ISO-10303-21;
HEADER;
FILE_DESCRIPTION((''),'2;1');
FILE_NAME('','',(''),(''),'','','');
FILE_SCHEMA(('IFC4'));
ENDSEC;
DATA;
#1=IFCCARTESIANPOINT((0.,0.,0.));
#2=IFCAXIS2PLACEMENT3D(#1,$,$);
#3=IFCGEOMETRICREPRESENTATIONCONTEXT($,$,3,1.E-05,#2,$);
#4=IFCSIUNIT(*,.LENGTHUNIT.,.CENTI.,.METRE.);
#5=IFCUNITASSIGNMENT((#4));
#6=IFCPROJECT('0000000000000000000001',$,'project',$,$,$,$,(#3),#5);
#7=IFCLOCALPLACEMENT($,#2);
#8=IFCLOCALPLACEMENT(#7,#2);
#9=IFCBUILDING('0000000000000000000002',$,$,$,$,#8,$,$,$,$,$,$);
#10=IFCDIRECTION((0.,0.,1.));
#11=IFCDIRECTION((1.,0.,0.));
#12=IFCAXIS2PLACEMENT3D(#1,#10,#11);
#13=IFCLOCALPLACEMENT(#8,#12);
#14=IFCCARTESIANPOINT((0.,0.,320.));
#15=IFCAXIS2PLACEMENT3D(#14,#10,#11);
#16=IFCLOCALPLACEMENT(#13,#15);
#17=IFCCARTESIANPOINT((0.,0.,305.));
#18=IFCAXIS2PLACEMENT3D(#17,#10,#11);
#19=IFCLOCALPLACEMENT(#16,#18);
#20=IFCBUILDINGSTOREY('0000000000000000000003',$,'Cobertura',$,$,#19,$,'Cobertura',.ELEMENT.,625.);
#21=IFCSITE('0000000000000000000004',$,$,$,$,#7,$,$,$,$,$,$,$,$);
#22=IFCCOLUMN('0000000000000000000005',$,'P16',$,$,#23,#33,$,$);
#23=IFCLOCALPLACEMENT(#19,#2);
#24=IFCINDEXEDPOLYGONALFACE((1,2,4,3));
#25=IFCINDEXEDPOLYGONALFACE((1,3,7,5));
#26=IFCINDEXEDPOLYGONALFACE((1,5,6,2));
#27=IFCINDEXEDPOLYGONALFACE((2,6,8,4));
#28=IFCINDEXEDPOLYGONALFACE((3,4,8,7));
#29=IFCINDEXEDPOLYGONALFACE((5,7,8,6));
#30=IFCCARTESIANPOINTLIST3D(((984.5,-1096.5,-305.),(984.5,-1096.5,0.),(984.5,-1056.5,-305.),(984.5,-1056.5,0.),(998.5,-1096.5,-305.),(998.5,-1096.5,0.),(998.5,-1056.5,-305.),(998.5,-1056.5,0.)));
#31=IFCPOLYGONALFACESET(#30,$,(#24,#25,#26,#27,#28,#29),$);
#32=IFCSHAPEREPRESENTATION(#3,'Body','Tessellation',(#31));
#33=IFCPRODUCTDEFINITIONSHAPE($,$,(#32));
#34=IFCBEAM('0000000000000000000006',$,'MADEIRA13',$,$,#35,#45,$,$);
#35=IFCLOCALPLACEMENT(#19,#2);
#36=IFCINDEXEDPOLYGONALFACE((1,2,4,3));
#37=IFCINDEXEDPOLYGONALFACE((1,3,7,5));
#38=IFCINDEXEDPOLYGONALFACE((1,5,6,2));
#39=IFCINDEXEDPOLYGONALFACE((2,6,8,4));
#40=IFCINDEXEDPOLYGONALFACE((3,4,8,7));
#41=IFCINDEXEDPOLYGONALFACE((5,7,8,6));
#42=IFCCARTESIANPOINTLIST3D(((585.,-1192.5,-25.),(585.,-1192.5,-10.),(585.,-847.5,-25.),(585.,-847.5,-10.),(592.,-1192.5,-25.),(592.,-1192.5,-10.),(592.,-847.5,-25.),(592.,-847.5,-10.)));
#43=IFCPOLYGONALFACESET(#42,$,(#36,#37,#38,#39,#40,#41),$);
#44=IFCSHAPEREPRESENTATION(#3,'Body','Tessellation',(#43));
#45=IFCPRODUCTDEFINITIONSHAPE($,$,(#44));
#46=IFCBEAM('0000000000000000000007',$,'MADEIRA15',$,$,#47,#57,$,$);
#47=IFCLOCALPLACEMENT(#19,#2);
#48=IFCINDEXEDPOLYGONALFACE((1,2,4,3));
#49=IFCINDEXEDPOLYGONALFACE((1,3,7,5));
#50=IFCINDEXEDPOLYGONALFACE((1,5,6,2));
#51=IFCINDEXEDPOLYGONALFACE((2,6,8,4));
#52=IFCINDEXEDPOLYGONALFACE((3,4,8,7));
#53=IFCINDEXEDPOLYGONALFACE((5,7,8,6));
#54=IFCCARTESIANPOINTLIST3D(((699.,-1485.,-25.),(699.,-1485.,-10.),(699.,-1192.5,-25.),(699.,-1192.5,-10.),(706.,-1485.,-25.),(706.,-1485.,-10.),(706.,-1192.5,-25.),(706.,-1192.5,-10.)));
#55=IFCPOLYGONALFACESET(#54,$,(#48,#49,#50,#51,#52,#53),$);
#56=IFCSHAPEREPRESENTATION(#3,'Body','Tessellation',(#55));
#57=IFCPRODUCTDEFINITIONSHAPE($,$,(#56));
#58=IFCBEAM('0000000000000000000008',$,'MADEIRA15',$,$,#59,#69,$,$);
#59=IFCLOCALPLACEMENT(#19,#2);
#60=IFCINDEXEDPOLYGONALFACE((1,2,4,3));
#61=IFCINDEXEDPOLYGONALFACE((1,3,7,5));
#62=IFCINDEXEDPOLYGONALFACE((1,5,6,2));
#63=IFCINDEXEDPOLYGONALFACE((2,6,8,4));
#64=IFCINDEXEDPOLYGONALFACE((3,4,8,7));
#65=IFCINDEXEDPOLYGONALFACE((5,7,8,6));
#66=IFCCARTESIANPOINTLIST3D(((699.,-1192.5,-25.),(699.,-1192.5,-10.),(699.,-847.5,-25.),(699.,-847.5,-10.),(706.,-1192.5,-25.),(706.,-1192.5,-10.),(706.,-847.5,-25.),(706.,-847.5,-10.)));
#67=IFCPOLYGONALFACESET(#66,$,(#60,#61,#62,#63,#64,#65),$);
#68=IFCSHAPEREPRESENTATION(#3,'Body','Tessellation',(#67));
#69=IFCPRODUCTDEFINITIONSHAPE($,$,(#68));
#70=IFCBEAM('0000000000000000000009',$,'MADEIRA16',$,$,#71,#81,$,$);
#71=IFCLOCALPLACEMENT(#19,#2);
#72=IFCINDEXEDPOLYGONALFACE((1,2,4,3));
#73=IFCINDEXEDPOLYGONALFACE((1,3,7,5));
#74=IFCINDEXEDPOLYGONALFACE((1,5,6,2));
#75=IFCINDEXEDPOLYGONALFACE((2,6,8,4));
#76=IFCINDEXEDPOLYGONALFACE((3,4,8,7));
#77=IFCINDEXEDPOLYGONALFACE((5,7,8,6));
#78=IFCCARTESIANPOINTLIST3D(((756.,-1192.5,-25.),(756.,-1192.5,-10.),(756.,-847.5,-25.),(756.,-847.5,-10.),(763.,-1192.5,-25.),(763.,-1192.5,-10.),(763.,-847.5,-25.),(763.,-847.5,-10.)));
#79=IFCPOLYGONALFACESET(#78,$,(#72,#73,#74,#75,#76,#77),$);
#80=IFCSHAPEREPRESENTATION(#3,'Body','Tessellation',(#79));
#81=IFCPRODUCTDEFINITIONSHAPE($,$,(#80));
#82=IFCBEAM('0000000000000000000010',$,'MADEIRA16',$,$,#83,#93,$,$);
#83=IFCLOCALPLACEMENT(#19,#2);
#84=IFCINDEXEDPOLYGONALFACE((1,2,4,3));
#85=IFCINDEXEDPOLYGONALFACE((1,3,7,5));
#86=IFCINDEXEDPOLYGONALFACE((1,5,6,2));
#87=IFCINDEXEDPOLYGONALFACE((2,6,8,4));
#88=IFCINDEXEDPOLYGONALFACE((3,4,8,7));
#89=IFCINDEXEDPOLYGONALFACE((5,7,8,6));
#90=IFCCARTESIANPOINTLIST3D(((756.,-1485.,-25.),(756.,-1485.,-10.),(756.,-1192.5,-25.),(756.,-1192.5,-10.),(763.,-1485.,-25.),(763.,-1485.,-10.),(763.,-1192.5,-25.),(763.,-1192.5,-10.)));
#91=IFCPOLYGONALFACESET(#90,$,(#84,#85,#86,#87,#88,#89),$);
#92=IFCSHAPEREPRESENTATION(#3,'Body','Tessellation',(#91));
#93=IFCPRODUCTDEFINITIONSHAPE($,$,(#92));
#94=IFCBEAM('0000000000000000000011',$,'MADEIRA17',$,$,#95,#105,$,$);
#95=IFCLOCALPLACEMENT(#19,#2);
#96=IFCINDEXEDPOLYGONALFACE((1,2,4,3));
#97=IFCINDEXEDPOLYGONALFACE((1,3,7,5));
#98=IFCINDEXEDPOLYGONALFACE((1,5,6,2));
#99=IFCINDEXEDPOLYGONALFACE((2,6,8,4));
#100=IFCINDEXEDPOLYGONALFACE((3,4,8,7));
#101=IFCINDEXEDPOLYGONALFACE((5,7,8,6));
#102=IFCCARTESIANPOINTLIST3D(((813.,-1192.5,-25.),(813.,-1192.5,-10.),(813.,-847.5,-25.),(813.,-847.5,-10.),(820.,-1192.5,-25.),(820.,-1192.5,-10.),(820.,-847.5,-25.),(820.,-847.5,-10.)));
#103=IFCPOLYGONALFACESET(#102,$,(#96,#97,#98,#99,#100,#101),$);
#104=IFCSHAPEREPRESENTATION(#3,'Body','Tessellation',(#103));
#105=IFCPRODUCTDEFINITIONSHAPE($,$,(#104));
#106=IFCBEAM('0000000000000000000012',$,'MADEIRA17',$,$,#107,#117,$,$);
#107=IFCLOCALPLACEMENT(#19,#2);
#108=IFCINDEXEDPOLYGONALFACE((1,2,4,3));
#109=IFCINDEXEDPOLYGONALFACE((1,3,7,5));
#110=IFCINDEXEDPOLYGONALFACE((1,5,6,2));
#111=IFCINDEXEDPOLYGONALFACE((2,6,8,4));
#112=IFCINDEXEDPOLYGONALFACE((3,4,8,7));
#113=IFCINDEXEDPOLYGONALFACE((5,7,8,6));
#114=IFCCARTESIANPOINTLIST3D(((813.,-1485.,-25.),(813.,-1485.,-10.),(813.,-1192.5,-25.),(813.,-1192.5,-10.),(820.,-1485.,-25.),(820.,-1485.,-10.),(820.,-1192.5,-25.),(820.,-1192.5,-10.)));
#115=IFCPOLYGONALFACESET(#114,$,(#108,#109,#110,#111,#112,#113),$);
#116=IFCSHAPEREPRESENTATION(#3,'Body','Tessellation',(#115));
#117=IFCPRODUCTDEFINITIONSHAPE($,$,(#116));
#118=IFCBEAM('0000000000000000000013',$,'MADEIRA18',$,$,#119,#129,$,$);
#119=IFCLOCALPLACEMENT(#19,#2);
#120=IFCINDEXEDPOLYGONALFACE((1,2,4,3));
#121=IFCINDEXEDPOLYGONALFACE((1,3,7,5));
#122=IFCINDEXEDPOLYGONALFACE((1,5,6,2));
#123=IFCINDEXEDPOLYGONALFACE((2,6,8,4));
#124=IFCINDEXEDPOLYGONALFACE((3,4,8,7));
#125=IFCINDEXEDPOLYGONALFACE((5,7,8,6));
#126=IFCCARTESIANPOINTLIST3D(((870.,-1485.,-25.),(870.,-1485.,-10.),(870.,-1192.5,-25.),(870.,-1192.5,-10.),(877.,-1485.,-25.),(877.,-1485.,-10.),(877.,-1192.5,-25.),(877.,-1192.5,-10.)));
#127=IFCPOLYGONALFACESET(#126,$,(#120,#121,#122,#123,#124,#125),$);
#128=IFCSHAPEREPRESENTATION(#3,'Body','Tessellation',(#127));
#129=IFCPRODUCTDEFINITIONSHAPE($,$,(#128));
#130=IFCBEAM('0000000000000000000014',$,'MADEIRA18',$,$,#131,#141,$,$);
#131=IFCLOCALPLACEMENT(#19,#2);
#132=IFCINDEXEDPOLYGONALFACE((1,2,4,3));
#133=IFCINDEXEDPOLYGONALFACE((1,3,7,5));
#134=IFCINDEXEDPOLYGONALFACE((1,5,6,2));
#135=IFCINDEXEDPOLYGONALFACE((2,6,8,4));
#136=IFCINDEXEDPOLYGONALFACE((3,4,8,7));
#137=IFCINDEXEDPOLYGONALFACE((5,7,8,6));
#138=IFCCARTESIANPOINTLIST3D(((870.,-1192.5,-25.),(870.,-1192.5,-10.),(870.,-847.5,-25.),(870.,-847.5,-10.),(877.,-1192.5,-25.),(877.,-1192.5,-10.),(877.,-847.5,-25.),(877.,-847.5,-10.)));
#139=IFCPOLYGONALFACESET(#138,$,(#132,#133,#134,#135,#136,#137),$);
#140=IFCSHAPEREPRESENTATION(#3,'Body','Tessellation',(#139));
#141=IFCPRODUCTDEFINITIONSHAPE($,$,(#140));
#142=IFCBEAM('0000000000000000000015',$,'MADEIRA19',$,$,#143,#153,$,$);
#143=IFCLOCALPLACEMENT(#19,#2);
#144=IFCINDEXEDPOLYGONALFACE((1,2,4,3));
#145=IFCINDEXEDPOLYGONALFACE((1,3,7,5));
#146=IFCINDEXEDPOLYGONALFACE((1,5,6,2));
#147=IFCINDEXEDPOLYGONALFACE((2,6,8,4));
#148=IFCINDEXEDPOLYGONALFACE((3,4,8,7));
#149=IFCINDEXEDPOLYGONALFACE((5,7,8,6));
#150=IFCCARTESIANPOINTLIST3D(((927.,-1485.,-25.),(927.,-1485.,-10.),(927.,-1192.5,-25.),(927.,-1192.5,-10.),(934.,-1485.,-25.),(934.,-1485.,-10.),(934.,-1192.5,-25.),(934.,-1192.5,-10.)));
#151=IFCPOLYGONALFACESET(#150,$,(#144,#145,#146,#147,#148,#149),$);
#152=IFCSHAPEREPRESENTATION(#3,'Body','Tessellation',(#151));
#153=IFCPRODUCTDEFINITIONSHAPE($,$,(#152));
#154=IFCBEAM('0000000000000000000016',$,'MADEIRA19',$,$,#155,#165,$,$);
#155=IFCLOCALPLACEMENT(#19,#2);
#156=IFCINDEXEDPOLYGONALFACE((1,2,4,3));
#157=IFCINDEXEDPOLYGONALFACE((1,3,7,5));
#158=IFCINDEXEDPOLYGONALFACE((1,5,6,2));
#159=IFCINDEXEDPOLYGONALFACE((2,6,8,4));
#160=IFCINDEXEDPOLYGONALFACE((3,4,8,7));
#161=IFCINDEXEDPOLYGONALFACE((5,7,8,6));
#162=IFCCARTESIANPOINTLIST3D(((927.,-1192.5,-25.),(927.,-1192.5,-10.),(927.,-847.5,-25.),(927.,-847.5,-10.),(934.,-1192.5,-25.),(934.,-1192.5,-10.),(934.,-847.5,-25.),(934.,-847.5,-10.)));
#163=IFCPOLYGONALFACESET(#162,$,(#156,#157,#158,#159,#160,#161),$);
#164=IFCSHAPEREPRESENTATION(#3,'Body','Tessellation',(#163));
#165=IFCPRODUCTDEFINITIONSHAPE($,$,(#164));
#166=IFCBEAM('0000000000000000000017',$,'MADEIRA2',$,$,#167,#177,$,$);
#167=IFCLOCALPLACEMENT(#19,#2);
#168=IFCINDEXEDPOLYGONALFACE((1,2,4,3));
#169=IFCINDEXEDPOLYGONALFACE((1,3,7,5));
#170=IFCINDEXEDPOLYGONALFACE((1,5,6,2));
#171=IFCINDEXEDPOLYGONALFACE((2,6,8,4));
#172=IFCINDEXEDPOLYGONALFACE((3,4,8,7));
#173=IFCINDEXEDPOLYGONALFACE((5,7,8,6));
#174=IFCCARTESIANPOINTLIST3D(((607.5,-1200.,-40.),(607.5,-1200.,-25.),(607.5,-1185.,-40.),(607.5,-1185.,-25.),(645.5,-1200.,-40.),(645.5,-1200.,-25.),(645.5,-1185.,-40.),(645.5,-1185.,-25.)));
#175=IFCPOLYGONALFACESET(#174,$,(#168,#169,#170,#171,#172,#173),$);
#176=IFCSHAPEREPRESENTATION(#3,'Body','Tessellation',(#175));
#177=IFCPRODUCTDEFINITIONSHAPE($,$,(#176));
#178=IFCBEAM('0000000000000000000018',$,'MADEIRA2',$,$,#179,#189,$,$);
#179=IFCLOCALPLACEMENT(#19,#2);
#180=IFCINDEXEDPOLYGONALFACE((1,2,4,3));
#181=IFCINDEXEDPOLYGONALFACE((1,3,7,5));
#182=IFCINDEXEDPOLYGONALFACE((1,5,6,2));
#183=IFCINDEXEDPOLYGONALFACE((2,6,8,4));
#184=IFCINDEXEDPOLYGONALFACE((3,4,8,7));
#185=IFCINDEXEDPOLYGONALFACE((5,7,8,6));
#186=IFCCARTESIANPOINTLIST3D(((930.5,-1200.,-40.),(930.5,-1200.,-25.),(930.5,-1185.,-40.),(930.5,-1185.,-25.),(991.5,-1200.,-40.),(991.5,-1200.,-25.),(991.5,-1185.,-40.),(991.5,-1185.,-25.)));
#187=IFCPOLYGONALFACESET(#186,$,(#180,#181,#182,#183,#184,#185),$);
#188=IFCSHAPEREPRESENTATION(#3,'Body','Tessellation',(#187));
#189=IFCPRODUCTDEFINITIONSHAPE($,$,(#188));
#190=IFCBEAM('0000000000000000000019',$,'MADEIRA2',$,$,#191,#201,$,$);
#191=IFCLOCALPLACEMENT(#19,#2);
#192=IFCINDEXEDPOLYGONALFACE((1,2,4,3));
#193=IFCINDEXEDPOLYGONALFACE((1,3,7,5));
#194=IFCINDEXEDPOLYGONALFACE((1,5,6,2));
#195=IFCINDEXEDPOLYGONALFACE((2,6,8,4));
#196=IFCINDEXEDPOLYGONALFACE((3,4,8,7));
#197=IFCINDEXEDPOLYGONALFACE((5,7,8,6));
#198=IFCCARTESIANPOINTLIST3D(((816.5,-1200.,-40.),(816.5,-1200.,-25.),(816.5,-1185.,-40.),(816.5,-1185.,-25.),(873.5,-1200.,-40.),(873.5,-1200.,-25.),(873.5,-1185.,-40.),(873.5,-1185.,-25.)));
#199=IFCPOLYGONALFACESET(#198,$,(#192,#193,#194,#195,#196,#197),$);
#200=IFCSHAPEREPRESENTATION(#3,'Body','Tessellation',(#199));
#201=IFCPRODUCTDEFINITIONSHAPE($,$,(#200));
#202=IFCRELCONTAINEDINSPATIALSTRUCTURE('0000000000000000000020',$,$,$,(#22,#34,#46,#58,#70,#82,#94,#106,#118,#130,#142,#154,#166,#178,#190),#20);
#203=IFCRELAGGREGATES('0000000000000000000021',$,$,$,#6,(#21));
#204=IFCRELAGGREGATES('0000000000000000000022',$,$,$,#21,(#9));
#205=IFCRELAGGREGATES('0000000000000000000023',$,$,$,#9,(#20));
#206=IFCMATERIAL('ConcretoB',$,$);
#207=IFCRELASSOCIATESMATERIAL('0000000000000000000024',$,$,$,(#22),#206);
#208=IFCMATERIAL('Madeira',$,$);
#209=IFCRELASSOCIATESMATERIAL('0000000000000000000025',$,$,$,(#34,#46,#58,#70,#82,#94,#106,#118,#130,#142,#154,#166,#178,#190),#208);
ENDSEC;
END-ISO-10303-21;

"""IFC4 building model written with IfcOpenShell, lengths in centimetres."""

from ifc_helpers import new_model, si_unit, frame, origin, origin_with_axes, place, context, project, spatial, polyline, outline, extrude, material, element, save


model = new_model("IFC4")

# Units and contexts
context_of_model = context(None, 3, precision=1e-05, world=origin())
ifc_project = project(units=[si_unit("LENGTHUNIT", "METRE", prefix="CENTI")], contexts=[context_of_model])

# Site, building, storey
site_placement = place(None, origin())
site = spatial("IfcSite", under=ifc_project, at=site_placement)
building_placement = place(site_placement, origin())
building = spatial("IfcBuilding", under=site, at=building_placement)
placement_1 = place(building_placement, origin_with_axes())
placement_2 = place(placement_1, frame((0.0, 0.0, 320.0), z_axis=(0.0, 0.0, 1.0), x_axis=(1.0, 0.0, 0.0)))
storey_placement = place(placement_2, frame((0.0, 0.0, 305.0), z_axis=(0.0, 0.0, 1.0), x_axis=(1.0, 0.0, 0.0)))
storey = spatial("IfcBuildingStorey", under=building, at=storey_placement, Name="Cobertura", LongName="Cobertura", CompositionType="ELEMENT", Elevation=625.0)

# Column
ifc_material_1 = material(Name="ConcretoB")
column_placement = place(storey_placement, frame((991.5, -1076.5, 0.0), z_axis=(0.0, 0.0, 1.0), x_axis=(1.0, 0.0, 0.0)))
element("IfcColumn", 1, at=column_placement, inside=storey, material=ifc_material_1, Name="P16", context=context_of_model, shape_type="SolidModel", body=[
    extrude(outline(polyline([(-7.0, -20.0), (7.0, -20.0), (7.0, 20.0), (-7.0, 20.0), (-7.0, -20.0)])), origin_with_axes(), (0.0, 0.0, -1.0), 305.0),
])

# Beams
ifc_material_2 = material(Name="Madeira")
beam_1_placement = place(storey_placement, frame((588.5, -1020.0, -10.0), z_axis=(0.0, 0.0, 1.0), x_axis=(1.0, 0.0, 0.0)))
element("IfcBeam", 2, at=beam_1_placement, inside=storey, material=ifc_material_2, Name="MADEIRA13", context=context_of_model, shape_type="SolidModel", body=[
    extrude(outline(polyline([(-3.5, -7.5), (-3.5, 7.5), (3.5, 7.5), (3.5, -7.5), (-3.5, -7.5)])), frame((0.0, -172.5, -7.5), z_axis=(0.0, 1.0, 0.0), x_axis=(1.0, 0.0, 0.0)), (0.0, 0.0, 1.0), 345.0),
])
beam_2_placement = place(storey_placement, frame((702.5, -1338.75, -10.0), z_axis=(0.0, 0.0, 1.0), x_axis=(1.0, 0.0, 0.0)))
element("IfcBeam", 3, at=beam_2_placement, inside=storey, material=ifc_material_2, Name="MADEIRA15", context=context_of_model, shape_type="SolidModel", body=[
    extrude(outline(polyline([(-3.5, -7.5), (-3.5, 7.5), (3.5, 7.5), (3.5, -7.5), (-3.5, -7.5)])), frame((0.0, -146.25, -7.5), z_axis=(0.0, 1.0, 0.0), x_axis=(1.0, 0.0, 0.0)), (0.0, 0.0, 1.0), 292.5),
])
for number, where, z_axis, x_axis, name in (
    (4, (702.5, -1020.0, -10.0), (0.0, 0.0, 1.0), (1.0, 0.0, 0.0), "MADEIRA15"),
    (5, (759.5, -1020.0, -10.0), (0.0, 0.0, 1.0), (1.0, 0.0, 0.0), "MADEIRA16"),
):
    element("IfcBeam", number, at=place(storey_placement, frame(where, z_axis=z_axis, x_axis=x_axis)), inside=storey, material=ifc_material_2, Name=name, context=context_of_model, shape_type="SolidModel", body=[
        extrude(outline(polyline([(-3.5, -7.5), (-3.5, 7.5), (3.5, 7.5), (3.5, -7.5), (-3.5, -7.5)])), frame((0.0, -172.5, -7.5), z_axis=(0.0, 1.0, 0.0), x_axis=(1.0, 0.0, 0.0)), (0.0, 0.0, 1.0), 345.0),
    ])
beam_3_placement = place(storey_placement, frame((759.5, -1338.75, -10.0), z_axis=(0.0, 0.0, 1.0), x_axis=(1.0, 0.0, 0.0)))
element("IfcBeam", 6, at=beam_3_placement, inside=storey, material=ifc_material_2, Name="MADEIRA16", context=context_of_model, shape_type="SolidModel", body=[
    extrude(outline(polyline([(-3.5, -7.5), (-3.5, 7.5), (3.5, 7.5), (3.5, -7.5), (-3.5, -7.5)])), frame((0.0, -146.25, -7.5), z_axis=(0.0, 1.0, 0.0), x_axis=(1.0, 0.0, 0.0)), (0.0, 0.0, 1.0), 292.5),
])
beam_4_placement = place(storey_placement, frame((816.5, -1020.0, -10.0), z_axis=(0.0, 0.0, 1.0), x_axis=(1.0, 0.0, 0.0)))
element("IfcBeam", 7, at=beam_4_placement, inside=storey, material=ifc_material_2, Name="MADEIRA17", context=context_of_model, shape_type="SolidModel", body=[
    extrude(outline(polyline([(-3.5, -7.5), (-3.5, 7.5), (3.5, 7.5), (3.5, -7.5), (-3.5, -7.5)])), frame((0.0, -172.5, -7.5), z_axis=(0.0, 1.0, 0.0), x_axis=(1.0, 0.0, 0.0)), (0.0, 0.0, 1.0), 345.0),
])
for number, where, z_axis, x_axis, name in (
    (8, (816.5, -1338.75, -10.0), (0.0, 0.0, 1.0), (1.0, 0.0, 0.0), "MADEIRA17"),
    (9, (873.5, -1338.75, -10.0), (0.0, 0.0, 1.0), (1.0, 0.0, 0.0), "MADEIRA18"),
):
    element("IfcBeam", number, at=place(storey_placement, frame(where, z_axis=z_axis, x_axis=x_axis)), inside=storey, material=ifc_material_2, Name=name, context=context_of_model, shape_type="SolidModel", body=[
        extrude(outline(polyline([(-3.5, -7.5), (-3.5, 7.5), (3.5, 7.5), (3.5, -7.5), (-3.5, -7.5)])), frame((0.0, -146.25, -7.5), z_axis=(0.0, 1.0, 0.0), x_axis=(1.0, 0.0, 0.0)), (0.0, 0.0, 1.0), 292.5),
    ])
beam_5_placement = place(storey_placement, frame((873.5, -1020.0, -10.0), z_axis=(0.0, 0.0, 1.0), x_axis=(1.0, 0.0, 0.0)))
element("IfcBeam", 10, at=beam_5_placement, inside=storey, material=ifc_material_2, Name="MADEIRA18", context=context_of_model, shape_type="SolidModel", body=[
    extrude(outline(polyline([(-3.5, -7.5), (-3.5, 7.5), (3.5, 7.5), (3.5, -7.5), (-3.5, -7.5)])), frame((0.0, -172.5, -7.5), z_axis=(0.0, 1.0, 0.0), x_axis=(1.0, 0.0, 0.0)), (0.0, 0.0, 1.0), 345.0),
])
beam_6_placement = place(storey_placement, frame((930.5, -1338.75, -10.0), z_axis=(0.0, 0.0, 1.0), x_axis=(1.0, 0.0, 0.0)))
element("IfcBeam", 11, at=beam_6_placement, inside=storey, material=ifc_material_2, Name="MADEIRA19", context=context_of_model, shape_type="SolidModel", body=[
    extrude(outline(polyline([(-3.5, -7.5), (-3.5, 7.5), (3.5, 7.5), (3.5, -7.5), (-3.5, -7.5)])), frame((0.0, -146.25, -7.5), z_axis=(0.0, 1.0, 0.0), x_axis=(1.0, 0.0, 0.0)), (0.0, 0.0, 1.0), 292.5),
])
beam_7_placement = place(storey_placement, frame((930.5, -1020.0, -10.0), z_axis=(0.0, 0.0, 1.0), x_axis=(1.0, 0.0, 0.0)))
element("IfcBeam", 12, at=beam_7_placement, inside=storey, material=ifc_material_2, Name="MADEIRA19", context=context_of_model, shape_type="SolidModel", body=[
    extrude(outline(polyline([(-3.5, -7.5), (-3.5, 7.5), (3.5, 7.5), (3.5, -7.5), (-3.5, -7.5)])), frame((0.0, -172.5, -7.5), z_axis=(0.0, 1.0, 0.0), x_axis=(1.0, 0.0, 0.0)), (0.0, 0.0, 1.0), 345.0),
])
beam_8_placement = place(storey_placement, frame((626.5, -1192.5, -25.0), z_axis=(0.0, 0.0, 1.0), x_axis=(1.0, 0.0, 0.0)))
element("IfcBeam", 13, at=beam_8_placement, inside=storey, material=ifc_material_2, Name="MADEIRA2", context=context_of_model, shape_type="SolidModel", body=[
    extrude(outline(polyline([(-7.5, -7.5), (-7.5, 7.5), (7.5, 7.5), (7.5, -7.5), (-7.5, -7.5)])), frame((-19.0, 0.0, -7.5), z_axis=(1.0, 0.0, 0.0), x_axis=(0.0, -1.0, 0.0)), (0.0, 0.0, 1.0), 38.0),
])
beam_9_placement = place(storey_placement, frame((961.0, -1192.5, -25.0), z_axis=(0.0, 0.0, 1.0), x_axis=(1.0, 0.0, 0.0)))
element("IfcBeam", 14, at=beam_9_placement, inside=storey, material=ifc_material_2, Name="MADEIRA2", context=context_of_model, shape_type="SolidModel", body=[
    extrude(outline(polyline([(-7.5, -7.5), (-7.5, 7.5), (7.5, 7.5), (7.5, -7.5), (-7.5, -7.5)])), frame((-30.5, 0.0, -7.5), z_axis=(1.0, 0.0, 0.0), x_axis=(0.0, -1.0, 0.0)), (0.0, 0.0, 1.0), 61.0),
])
for number, where, z_axis, x_axis, name in (
    (15, (845.0, -1192.5, -25.0), (0.0, 0.0, 1.0), (1.0, 0.0, 0.0), "MADEIRA2"),
):
    element("IfcBeam", number, at=place(storey_placement, frame(where, z_axis=z_axis, x_axis=x_axis)), inside=storey, material=ifc_material_2, Name=name, context=context_of_model, shape_type="SolidModel", body=[
        extrude(outline(polyline([(-7.5, -7.5), (-7.5, 7.5), (7.5, 7.5), (7.5, -7.5), (-7.5, -7.5)])), frame((-28.5, 0.0, -7.5), z_axis=(1.0, 0.0, 0.0), x_axis=(0.0, -1.0, 0.0)), (0.0, 0.0, 1.0), 57.0),
    ])

save(model, "model.ifc")
